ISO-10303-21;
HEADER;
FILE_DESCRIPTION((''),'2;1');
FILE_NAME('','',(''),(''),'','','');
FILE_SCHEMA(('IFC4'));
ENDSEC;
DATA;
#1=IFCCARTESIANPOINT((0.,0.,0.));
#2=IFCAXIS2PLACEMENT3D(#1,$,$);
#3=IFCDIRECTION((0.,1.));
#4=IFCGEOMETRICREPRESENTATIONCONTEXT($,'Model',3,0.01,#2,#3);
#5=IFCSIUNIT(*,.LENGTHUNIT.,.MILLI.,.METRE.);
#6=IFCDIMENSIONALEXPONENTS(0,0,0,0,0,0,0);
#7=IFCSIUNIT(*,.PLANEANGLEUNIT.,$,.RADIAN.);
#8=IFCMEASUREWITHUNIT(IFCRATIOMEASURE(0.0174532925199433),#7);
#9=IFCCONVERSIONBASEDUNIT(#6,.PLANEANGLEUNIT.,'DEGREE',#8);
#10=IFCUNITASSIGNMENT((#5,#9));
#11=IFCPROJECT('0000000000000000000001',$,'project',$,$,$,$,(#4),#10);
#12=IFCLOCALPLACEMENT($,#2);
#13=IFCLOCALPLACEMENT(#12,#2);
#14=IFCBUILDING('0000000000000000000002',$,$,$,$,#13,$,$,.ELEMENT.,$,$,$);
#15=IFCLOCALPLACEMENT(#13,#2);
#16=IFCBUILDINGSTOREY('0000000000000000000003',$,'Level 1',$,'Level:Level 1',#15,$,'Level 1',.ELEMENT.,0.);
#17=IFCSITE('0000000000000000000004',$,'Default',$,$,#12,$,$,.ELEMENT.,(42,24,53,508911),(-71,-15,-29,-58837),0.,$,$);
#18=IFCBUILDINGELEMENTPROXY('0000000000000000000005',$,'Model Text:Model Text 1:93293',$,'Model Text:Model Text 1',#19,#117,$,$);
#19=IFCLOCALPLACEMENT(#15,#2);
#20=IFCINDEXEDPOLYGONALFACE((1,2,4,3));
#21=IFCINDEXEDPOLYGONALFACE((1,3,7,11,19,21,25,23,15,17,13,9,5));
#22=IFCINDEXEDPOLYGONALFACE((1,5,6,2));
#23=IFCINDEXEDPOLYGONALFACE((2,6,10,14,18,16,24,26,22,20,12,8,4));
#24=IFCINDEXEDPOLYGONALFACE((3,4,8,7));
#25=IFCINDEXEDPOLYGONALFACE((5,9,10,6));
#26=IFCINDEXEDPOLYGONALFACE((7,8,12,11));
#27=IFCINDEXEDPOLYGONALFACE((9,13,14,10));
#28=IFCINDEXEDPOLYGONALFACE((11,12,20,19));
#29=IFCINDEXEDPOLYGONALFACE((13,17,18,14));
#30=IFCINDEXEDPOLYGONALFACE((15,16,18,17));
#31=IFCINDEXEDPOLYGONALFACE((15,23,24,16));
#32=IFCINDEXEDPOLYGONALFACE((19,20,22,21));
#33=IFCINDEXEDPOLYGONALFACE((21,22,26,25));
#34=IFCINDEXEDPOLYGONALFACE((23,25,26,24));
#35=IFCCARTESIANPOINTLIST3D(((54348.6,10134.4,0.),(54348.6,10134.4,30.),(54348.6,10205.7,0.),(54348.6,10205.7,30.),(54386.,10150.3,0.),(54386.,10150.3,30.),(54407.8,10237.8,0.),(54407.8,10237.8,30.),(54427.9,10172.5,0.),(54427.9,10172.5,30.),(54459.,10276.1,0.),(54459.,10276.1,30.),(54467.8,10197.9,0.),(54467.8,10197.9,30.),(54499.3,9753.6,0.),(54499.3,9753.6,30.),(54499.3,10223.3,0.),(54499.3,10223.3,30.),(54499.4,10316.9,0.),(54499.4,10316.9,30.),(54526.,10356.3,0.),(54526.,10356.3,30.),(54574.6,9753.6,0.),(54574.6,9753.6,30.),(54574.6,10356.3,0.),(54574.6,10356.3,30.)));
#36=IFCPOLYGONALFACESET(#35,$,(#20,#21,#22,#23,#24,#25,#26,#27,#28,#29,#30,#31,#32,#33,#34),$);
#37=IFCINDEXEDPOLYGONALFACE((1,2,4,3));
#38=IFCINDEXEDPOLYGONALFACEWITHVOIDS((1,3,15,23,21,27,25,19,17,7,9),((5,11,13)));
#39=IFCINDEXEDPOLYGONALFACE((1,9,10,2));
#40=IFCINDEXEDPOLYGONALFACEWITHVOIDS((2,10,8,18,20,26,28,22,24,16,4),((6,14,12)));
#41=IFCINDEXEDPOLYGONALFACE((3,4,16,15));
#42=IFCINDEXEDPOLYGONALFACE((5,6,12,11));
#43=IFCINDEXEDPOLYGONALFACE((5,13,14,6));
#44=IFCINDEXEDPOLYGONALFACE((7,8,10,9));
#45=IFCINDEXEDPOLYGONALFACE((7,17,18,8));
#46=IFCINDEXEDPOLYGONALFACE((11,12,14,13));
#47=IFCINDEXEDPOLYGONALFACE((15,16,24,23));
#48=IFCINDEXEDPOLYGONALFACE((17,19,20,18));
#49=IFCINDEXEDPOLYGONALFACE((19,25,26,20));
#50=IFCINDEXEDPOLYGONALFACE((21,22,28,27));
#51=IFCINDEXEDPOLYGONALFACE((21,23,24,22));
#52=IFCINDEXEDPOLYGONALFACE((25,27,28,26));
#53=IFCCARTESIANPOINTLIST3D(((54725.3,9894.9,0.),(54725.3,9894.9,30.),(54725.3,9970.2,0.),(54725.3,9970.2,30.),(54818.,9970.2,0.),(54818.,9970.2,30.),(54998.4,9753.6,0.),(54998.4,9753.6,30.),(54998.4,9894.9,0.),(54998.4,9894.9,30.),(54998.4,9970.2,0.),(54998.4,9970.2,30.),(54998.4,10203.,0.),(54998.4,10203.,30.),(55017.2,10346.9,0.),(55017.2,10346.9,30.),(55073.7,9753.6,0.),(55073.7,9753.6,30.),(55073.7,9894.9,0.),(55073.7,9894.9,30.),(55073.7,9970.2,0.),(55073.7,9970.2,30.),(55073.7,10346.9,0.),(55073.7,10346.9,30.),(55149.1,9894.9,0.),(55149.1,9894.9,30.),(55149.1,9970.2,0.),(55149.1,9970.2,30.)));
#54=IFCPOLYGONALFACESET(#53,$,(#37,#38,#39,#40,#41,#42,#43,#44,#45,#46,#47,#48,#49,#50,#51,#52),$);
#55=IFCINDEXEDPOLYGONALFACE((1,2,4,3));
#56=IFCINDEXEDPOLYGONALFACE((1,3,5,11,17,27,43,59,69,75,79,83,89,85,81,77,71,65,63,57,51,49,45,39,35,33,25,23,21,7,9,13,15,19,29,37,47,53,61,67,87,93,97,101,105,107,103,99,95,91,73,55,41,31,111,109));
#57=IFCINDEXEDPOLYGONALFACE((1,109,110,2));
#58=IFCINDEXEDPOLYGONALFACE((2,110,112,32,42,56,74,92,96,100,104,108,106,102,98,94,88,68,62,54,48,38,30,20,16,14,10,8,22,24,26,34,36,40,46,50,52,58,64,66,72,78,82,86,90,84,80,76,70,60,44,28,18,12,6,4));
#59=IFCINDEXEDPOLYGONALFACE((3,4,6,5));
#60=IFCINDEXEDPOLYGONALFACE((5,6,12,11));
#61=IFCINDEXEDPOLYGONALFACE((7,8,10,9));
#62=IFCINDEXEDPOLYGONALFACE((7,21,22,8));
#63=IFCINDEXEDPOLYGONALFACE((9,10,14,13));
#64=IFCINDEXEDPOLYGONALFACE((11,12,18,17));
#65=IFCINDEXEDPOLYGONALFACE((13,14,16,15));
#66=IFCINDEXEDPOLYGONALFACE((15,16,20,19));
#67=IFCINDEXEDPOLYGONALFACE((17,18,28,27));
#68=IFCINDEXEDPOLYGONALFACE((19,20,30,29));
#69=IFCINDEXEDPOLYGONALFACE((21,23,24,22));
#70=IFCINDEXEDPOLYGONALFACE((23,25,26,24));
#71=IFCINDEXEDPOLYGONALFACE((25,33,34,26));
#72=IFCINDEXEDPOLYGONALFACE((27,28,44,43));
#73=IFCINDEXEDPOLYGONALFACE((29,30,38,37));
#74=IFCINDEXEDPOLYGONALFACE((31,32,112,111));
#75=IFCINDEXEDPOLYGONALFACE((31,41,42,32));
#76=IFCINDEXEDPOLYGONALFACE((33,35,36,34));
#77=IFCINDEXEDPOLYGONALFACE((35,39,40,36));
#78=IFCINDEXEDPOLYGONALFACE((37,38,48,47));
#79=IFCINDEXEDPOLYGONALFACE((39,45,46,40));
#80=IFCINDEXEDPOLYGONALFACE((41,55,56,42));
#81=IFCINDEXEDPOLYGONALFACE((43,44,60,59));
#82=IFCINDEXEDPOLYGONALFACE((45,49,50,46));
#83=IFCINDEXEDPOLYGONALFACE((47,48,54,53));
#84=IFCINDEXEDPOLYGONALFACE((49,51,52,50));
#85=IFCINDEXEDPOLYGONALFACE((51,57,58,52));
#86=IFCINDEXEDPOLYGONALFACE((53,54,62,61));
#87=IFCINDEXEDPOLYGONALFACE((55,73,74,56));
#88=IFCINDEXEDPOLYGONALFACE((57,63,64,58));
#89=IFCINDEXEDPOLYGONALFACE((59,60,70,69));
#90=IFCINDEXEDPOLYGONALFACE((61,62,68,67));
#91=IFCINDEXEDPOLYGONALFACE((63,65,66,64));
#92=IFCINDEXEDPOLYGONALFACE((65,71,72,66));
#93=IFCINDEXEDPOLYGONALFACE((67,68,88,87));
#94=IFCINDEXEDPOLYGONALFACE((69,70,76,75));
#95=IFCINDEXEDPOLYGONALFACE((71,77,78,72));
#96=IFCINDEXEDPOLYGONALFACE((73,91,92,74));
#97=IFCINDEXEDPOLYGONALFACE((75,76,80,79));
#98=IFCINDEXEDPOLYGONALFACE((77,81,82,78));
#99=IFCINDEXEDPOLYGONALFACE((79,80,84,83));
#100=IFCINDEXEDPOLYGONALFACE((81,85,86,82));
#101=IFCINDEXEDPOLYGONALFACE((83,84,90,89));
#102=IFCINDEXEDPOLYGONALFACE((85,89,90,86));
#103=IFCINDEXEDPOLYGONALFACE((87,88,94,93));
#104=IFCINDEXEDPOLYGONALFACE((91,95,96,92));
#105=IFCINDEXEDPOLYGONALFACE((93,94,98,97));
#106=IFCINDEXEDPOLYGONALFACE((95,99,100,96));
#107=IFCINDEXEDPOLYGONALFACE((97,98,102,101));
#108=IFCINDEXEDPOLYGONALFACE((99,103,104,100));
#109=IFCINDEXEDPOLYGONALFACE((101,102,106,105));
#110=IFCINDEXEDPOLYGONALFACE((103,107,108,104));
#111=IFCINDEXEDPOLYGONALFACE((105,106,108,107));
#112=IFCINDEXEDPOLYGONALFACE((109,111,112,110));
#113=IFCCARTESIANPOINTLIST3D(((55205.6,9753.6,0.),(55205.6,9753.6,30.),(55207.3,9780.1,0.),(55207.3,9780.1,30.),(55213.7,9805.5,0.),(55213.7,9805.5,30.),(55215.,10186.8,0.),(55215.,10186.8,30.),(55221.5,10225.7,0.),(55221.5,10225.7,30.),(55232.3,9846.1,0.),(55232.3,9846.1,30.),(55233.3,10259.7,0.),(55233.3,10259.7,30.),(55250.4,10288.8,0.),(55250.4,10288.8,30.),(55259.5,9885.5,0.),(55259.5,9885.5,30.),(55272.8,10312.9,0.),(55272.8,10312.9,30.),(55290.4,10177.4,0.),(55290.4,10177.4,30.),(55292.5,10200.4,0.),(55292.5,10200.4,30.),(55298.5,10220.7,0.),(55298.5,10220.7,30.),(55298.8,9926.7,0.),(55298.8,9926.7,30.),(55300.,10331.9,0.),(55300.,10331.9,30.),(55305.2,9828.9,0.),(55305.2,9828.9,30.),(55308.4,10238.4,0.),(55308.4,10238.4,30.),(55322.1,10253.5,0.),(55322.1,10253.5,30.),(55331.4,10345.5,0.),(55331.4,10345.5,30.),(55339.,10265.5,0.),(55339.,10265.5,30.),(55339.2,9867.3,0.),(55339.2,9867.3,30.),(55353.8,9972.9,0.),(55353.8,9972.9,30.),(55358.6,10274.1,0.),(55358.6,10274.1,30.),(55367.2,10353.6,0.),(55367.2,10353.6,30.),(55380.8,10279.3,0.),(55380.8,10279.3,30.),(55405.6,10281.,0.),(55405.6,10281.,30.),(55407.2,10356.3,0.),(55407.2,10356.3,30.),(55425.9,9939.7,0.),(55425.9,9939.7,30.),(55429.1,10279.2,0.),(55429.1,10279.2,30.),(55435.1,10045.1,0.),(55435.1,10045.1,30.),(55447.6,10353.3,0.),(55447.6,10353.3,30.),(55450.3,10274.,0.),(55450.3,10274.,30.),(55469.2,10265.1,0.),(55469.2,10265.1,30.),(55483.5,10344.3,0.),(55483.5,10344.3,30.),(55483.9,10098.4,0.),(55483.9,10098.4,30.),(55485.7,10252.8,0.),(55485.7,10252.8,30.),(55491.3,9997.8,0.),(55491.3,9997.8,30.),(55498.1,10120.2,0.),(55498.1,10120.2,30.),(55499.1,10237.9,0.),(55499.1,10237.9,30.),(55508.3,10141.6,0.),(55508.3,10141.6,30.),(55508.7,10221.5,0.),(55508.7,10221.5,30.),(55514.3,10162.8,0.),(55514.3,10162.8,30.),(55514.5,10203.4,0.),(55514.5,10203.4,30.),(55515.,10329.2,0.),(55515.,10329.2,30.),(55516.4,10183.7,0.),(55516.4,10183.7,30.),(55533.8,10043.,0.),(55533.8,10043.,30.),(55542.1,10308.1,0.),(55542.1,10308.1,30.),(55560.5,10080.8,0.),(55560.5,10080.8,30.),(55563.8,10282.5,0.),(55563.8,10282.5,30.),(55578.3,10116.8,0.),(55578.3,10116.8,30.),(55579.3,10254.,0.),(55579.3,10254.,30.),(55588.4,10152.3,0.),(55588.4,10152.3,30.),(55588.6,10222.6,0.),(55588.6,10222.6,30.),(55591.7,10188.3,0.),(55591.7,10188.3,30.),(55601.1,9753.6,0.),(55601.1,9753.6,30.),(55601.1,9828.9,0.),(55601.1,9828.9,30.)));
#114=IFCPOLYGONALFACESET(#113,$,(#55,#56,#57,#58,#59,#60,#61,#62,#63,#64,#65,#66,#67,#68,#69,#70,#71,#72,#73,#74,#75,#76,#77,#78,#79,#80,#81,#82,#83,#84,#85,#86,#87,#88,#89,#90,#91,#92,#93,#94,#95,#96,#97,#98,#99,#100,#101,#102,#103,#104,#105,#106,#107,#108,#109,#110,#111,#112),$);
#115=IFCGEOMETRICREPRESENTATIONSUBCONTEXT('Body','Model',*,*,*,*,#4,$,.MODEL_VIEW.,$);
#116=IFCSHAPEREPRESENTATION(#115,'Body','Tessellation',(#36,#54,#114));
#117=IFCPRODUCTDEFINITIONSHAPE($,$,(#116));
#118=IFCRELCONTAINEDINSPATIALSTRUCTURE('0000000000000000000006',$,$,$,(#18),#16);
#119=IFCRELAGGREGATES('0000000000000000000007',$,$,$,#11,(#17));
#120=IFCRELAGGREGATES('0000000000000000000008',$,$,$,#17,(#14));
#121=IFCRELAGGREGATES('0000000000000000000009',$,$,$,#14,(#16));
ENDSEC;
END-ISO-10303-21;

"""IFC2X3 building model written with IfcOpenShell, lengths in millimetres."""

from ifc_helpers import new_model, entity, si_unit, converted_unit, direction, frame, origin, place, context, subcontext, project, spatial, polyline, outline, extrude, element, save


model = new_model("IFC2X3")

# Units and contexts
model_context = context("Model", 3, precision=0.01, world=origin(), true_north=direction((0.0, 1.0)))
body_context = subcontext(model_context, "Body", "Model", "MODEL_VIEW")
ifc_project = project(units=[si_unit("LENGTHUNIT", "METRE", prefix="MILLI"), converted_unit("PLANEANGLEUNIT", "DEGREE", entity("IfcRatioMeasure", 0.0174532925199433), si_unit("PLANEANGLEUNIT", "RADIAN"), dimensions=[0, 0, 0, 0, 0, 0, 0])], contexts=[model_context])

# Site, building, storey
site_placement = place(None, origin())
site = spatial("IfcSite", under=ifc_project, at=site_placement, Name="Default", CompositionType="ELEMENT", RefLatitude=(42, 24, 53, 508911), RefLongitude=(-71, -15, -29, -58837), RefElevation=0.0)
building_placement = place(site_placement, origin())
building = spatial("IfcBuilding", under=site, at=building_placement, CompositionType="ELEMENT")
storey_placement = place(building_placement, origin())
storey = spatial("IfcBuildingStorey", under=building, at=storey_placement, Name="Level 1", ObjectType="Level:Level 1", LongName="Level 1", CompositionType="ELEMENT", Elevation=0.0)

# Building element proxy
proxy_1_placement = place(storey_placement, origin())
element("IfcBuildingElementProxy", 1, at=proxy_1_placement, inside=storey, Name="Model Text:Model Text 1:93293", ObjectType="Model Text:Model Text 1", context=body_context, shape_type="SweptSolid", body=[
    extrude(outline(polyline([(-410.6, -111.6), (192.1, -111.6), (192.1, -63.1), (152.7, -36.4), (111.9, 4.0), (73.6, 55.2), (41.4, 114.4), (-29.8, 114.4), (-13.9, 77.0), (8.3, 35.1), (33.7, -4.8), (59.1, -36.3), (-410.6, -36.3), (-410.6, -111.6)])), frame((54463.0, 10164.2, 0.0), z_axis=(0.0, 0.0, 1.0), x_axis=(0.0, 1.0, 0.0)), (0.0, 0.0, 1.0), 30.0),
    extrude(outline(polyline([(-6.8, -218.3), (68.5, -218.3), (68.5, -77.1), (143.8, -77.1), (143.8, -1.7), (68.5, -1.7), (68.5, 375.0), (12.0, 375.0), (-280.0, -1.7), (-280.0, -77.1), (-6.8, -77.1), (-6.8, -218.3)]), holes=[polyline([(-6.8, -1.7), (-187.3, -1.7), (-6.8, 231.1), (-6.8, -1.7)])]), frame((55005.3, 9971.9, 0.0)), (0.0, 0.0, 1.0), 30.0),
    extrude(outline(polyline([(-190.2, -317.5), (-190.2, -392.8), (205.4, -392.8), (203.7, -366.3), (197.3, -340.9), (178.7, -300.3), (151.5, -260.9), (112.2, -219.7), (57.2, -173.6), (-24.1, -101.3), (-72.9, -48.0), (-87.1, -26.3), (-97.3, -4.8), (-103.4, 16.4), (-105.4, 37.3), (-103.5, 57.0), (-97.7, 75.0), (-88.2, 91.5), (-74.7, 106.4), (-58.2, 118.7), (-39.4, 127.5), (-18.2, 132.8), (5.4, 134.6), (30.2, 132.9), (52.4, 127.7), (72.0, 119.1), (88.9, 107.1), (102.6, 92.0), (112.5, 74.3), (118.5, 54.0), (120.6, 31.0), (196.0, 40.4), (189.5, 79.3), (177.7, 113.3), (160.6, 142.4), (138.2, 166.5), (111.0, 185.5), (79.5, 199.1), (43.8, 207.2), (3.8, 209.9), (-36.6, 206.9), (-72.5, 197.9), (-104.0, 182.8), (-131.1, 161.7), (-152.8, 136.1), (-168.3, 107.6), (-177.6, 76.2), (-180.8, 41.9), (-177.4, 5.8), (-167.4, -29.6), (-149.5, -65.6), (-122.8, -103.4), (-80.3, -148.6), (-14.9, -206.7), (71.8, -279.1), (105.8, -317.5), (-190.2, -317.5)])), frame((55411.0, 10146.4, 0.0), z_axis=(0.0, 0.0, -1.0), x_axis=(-1.0, 0.0, 0.0)), (0.0, 0.0, -1.0), 30.0),
])

save(model, "model.ifc")
